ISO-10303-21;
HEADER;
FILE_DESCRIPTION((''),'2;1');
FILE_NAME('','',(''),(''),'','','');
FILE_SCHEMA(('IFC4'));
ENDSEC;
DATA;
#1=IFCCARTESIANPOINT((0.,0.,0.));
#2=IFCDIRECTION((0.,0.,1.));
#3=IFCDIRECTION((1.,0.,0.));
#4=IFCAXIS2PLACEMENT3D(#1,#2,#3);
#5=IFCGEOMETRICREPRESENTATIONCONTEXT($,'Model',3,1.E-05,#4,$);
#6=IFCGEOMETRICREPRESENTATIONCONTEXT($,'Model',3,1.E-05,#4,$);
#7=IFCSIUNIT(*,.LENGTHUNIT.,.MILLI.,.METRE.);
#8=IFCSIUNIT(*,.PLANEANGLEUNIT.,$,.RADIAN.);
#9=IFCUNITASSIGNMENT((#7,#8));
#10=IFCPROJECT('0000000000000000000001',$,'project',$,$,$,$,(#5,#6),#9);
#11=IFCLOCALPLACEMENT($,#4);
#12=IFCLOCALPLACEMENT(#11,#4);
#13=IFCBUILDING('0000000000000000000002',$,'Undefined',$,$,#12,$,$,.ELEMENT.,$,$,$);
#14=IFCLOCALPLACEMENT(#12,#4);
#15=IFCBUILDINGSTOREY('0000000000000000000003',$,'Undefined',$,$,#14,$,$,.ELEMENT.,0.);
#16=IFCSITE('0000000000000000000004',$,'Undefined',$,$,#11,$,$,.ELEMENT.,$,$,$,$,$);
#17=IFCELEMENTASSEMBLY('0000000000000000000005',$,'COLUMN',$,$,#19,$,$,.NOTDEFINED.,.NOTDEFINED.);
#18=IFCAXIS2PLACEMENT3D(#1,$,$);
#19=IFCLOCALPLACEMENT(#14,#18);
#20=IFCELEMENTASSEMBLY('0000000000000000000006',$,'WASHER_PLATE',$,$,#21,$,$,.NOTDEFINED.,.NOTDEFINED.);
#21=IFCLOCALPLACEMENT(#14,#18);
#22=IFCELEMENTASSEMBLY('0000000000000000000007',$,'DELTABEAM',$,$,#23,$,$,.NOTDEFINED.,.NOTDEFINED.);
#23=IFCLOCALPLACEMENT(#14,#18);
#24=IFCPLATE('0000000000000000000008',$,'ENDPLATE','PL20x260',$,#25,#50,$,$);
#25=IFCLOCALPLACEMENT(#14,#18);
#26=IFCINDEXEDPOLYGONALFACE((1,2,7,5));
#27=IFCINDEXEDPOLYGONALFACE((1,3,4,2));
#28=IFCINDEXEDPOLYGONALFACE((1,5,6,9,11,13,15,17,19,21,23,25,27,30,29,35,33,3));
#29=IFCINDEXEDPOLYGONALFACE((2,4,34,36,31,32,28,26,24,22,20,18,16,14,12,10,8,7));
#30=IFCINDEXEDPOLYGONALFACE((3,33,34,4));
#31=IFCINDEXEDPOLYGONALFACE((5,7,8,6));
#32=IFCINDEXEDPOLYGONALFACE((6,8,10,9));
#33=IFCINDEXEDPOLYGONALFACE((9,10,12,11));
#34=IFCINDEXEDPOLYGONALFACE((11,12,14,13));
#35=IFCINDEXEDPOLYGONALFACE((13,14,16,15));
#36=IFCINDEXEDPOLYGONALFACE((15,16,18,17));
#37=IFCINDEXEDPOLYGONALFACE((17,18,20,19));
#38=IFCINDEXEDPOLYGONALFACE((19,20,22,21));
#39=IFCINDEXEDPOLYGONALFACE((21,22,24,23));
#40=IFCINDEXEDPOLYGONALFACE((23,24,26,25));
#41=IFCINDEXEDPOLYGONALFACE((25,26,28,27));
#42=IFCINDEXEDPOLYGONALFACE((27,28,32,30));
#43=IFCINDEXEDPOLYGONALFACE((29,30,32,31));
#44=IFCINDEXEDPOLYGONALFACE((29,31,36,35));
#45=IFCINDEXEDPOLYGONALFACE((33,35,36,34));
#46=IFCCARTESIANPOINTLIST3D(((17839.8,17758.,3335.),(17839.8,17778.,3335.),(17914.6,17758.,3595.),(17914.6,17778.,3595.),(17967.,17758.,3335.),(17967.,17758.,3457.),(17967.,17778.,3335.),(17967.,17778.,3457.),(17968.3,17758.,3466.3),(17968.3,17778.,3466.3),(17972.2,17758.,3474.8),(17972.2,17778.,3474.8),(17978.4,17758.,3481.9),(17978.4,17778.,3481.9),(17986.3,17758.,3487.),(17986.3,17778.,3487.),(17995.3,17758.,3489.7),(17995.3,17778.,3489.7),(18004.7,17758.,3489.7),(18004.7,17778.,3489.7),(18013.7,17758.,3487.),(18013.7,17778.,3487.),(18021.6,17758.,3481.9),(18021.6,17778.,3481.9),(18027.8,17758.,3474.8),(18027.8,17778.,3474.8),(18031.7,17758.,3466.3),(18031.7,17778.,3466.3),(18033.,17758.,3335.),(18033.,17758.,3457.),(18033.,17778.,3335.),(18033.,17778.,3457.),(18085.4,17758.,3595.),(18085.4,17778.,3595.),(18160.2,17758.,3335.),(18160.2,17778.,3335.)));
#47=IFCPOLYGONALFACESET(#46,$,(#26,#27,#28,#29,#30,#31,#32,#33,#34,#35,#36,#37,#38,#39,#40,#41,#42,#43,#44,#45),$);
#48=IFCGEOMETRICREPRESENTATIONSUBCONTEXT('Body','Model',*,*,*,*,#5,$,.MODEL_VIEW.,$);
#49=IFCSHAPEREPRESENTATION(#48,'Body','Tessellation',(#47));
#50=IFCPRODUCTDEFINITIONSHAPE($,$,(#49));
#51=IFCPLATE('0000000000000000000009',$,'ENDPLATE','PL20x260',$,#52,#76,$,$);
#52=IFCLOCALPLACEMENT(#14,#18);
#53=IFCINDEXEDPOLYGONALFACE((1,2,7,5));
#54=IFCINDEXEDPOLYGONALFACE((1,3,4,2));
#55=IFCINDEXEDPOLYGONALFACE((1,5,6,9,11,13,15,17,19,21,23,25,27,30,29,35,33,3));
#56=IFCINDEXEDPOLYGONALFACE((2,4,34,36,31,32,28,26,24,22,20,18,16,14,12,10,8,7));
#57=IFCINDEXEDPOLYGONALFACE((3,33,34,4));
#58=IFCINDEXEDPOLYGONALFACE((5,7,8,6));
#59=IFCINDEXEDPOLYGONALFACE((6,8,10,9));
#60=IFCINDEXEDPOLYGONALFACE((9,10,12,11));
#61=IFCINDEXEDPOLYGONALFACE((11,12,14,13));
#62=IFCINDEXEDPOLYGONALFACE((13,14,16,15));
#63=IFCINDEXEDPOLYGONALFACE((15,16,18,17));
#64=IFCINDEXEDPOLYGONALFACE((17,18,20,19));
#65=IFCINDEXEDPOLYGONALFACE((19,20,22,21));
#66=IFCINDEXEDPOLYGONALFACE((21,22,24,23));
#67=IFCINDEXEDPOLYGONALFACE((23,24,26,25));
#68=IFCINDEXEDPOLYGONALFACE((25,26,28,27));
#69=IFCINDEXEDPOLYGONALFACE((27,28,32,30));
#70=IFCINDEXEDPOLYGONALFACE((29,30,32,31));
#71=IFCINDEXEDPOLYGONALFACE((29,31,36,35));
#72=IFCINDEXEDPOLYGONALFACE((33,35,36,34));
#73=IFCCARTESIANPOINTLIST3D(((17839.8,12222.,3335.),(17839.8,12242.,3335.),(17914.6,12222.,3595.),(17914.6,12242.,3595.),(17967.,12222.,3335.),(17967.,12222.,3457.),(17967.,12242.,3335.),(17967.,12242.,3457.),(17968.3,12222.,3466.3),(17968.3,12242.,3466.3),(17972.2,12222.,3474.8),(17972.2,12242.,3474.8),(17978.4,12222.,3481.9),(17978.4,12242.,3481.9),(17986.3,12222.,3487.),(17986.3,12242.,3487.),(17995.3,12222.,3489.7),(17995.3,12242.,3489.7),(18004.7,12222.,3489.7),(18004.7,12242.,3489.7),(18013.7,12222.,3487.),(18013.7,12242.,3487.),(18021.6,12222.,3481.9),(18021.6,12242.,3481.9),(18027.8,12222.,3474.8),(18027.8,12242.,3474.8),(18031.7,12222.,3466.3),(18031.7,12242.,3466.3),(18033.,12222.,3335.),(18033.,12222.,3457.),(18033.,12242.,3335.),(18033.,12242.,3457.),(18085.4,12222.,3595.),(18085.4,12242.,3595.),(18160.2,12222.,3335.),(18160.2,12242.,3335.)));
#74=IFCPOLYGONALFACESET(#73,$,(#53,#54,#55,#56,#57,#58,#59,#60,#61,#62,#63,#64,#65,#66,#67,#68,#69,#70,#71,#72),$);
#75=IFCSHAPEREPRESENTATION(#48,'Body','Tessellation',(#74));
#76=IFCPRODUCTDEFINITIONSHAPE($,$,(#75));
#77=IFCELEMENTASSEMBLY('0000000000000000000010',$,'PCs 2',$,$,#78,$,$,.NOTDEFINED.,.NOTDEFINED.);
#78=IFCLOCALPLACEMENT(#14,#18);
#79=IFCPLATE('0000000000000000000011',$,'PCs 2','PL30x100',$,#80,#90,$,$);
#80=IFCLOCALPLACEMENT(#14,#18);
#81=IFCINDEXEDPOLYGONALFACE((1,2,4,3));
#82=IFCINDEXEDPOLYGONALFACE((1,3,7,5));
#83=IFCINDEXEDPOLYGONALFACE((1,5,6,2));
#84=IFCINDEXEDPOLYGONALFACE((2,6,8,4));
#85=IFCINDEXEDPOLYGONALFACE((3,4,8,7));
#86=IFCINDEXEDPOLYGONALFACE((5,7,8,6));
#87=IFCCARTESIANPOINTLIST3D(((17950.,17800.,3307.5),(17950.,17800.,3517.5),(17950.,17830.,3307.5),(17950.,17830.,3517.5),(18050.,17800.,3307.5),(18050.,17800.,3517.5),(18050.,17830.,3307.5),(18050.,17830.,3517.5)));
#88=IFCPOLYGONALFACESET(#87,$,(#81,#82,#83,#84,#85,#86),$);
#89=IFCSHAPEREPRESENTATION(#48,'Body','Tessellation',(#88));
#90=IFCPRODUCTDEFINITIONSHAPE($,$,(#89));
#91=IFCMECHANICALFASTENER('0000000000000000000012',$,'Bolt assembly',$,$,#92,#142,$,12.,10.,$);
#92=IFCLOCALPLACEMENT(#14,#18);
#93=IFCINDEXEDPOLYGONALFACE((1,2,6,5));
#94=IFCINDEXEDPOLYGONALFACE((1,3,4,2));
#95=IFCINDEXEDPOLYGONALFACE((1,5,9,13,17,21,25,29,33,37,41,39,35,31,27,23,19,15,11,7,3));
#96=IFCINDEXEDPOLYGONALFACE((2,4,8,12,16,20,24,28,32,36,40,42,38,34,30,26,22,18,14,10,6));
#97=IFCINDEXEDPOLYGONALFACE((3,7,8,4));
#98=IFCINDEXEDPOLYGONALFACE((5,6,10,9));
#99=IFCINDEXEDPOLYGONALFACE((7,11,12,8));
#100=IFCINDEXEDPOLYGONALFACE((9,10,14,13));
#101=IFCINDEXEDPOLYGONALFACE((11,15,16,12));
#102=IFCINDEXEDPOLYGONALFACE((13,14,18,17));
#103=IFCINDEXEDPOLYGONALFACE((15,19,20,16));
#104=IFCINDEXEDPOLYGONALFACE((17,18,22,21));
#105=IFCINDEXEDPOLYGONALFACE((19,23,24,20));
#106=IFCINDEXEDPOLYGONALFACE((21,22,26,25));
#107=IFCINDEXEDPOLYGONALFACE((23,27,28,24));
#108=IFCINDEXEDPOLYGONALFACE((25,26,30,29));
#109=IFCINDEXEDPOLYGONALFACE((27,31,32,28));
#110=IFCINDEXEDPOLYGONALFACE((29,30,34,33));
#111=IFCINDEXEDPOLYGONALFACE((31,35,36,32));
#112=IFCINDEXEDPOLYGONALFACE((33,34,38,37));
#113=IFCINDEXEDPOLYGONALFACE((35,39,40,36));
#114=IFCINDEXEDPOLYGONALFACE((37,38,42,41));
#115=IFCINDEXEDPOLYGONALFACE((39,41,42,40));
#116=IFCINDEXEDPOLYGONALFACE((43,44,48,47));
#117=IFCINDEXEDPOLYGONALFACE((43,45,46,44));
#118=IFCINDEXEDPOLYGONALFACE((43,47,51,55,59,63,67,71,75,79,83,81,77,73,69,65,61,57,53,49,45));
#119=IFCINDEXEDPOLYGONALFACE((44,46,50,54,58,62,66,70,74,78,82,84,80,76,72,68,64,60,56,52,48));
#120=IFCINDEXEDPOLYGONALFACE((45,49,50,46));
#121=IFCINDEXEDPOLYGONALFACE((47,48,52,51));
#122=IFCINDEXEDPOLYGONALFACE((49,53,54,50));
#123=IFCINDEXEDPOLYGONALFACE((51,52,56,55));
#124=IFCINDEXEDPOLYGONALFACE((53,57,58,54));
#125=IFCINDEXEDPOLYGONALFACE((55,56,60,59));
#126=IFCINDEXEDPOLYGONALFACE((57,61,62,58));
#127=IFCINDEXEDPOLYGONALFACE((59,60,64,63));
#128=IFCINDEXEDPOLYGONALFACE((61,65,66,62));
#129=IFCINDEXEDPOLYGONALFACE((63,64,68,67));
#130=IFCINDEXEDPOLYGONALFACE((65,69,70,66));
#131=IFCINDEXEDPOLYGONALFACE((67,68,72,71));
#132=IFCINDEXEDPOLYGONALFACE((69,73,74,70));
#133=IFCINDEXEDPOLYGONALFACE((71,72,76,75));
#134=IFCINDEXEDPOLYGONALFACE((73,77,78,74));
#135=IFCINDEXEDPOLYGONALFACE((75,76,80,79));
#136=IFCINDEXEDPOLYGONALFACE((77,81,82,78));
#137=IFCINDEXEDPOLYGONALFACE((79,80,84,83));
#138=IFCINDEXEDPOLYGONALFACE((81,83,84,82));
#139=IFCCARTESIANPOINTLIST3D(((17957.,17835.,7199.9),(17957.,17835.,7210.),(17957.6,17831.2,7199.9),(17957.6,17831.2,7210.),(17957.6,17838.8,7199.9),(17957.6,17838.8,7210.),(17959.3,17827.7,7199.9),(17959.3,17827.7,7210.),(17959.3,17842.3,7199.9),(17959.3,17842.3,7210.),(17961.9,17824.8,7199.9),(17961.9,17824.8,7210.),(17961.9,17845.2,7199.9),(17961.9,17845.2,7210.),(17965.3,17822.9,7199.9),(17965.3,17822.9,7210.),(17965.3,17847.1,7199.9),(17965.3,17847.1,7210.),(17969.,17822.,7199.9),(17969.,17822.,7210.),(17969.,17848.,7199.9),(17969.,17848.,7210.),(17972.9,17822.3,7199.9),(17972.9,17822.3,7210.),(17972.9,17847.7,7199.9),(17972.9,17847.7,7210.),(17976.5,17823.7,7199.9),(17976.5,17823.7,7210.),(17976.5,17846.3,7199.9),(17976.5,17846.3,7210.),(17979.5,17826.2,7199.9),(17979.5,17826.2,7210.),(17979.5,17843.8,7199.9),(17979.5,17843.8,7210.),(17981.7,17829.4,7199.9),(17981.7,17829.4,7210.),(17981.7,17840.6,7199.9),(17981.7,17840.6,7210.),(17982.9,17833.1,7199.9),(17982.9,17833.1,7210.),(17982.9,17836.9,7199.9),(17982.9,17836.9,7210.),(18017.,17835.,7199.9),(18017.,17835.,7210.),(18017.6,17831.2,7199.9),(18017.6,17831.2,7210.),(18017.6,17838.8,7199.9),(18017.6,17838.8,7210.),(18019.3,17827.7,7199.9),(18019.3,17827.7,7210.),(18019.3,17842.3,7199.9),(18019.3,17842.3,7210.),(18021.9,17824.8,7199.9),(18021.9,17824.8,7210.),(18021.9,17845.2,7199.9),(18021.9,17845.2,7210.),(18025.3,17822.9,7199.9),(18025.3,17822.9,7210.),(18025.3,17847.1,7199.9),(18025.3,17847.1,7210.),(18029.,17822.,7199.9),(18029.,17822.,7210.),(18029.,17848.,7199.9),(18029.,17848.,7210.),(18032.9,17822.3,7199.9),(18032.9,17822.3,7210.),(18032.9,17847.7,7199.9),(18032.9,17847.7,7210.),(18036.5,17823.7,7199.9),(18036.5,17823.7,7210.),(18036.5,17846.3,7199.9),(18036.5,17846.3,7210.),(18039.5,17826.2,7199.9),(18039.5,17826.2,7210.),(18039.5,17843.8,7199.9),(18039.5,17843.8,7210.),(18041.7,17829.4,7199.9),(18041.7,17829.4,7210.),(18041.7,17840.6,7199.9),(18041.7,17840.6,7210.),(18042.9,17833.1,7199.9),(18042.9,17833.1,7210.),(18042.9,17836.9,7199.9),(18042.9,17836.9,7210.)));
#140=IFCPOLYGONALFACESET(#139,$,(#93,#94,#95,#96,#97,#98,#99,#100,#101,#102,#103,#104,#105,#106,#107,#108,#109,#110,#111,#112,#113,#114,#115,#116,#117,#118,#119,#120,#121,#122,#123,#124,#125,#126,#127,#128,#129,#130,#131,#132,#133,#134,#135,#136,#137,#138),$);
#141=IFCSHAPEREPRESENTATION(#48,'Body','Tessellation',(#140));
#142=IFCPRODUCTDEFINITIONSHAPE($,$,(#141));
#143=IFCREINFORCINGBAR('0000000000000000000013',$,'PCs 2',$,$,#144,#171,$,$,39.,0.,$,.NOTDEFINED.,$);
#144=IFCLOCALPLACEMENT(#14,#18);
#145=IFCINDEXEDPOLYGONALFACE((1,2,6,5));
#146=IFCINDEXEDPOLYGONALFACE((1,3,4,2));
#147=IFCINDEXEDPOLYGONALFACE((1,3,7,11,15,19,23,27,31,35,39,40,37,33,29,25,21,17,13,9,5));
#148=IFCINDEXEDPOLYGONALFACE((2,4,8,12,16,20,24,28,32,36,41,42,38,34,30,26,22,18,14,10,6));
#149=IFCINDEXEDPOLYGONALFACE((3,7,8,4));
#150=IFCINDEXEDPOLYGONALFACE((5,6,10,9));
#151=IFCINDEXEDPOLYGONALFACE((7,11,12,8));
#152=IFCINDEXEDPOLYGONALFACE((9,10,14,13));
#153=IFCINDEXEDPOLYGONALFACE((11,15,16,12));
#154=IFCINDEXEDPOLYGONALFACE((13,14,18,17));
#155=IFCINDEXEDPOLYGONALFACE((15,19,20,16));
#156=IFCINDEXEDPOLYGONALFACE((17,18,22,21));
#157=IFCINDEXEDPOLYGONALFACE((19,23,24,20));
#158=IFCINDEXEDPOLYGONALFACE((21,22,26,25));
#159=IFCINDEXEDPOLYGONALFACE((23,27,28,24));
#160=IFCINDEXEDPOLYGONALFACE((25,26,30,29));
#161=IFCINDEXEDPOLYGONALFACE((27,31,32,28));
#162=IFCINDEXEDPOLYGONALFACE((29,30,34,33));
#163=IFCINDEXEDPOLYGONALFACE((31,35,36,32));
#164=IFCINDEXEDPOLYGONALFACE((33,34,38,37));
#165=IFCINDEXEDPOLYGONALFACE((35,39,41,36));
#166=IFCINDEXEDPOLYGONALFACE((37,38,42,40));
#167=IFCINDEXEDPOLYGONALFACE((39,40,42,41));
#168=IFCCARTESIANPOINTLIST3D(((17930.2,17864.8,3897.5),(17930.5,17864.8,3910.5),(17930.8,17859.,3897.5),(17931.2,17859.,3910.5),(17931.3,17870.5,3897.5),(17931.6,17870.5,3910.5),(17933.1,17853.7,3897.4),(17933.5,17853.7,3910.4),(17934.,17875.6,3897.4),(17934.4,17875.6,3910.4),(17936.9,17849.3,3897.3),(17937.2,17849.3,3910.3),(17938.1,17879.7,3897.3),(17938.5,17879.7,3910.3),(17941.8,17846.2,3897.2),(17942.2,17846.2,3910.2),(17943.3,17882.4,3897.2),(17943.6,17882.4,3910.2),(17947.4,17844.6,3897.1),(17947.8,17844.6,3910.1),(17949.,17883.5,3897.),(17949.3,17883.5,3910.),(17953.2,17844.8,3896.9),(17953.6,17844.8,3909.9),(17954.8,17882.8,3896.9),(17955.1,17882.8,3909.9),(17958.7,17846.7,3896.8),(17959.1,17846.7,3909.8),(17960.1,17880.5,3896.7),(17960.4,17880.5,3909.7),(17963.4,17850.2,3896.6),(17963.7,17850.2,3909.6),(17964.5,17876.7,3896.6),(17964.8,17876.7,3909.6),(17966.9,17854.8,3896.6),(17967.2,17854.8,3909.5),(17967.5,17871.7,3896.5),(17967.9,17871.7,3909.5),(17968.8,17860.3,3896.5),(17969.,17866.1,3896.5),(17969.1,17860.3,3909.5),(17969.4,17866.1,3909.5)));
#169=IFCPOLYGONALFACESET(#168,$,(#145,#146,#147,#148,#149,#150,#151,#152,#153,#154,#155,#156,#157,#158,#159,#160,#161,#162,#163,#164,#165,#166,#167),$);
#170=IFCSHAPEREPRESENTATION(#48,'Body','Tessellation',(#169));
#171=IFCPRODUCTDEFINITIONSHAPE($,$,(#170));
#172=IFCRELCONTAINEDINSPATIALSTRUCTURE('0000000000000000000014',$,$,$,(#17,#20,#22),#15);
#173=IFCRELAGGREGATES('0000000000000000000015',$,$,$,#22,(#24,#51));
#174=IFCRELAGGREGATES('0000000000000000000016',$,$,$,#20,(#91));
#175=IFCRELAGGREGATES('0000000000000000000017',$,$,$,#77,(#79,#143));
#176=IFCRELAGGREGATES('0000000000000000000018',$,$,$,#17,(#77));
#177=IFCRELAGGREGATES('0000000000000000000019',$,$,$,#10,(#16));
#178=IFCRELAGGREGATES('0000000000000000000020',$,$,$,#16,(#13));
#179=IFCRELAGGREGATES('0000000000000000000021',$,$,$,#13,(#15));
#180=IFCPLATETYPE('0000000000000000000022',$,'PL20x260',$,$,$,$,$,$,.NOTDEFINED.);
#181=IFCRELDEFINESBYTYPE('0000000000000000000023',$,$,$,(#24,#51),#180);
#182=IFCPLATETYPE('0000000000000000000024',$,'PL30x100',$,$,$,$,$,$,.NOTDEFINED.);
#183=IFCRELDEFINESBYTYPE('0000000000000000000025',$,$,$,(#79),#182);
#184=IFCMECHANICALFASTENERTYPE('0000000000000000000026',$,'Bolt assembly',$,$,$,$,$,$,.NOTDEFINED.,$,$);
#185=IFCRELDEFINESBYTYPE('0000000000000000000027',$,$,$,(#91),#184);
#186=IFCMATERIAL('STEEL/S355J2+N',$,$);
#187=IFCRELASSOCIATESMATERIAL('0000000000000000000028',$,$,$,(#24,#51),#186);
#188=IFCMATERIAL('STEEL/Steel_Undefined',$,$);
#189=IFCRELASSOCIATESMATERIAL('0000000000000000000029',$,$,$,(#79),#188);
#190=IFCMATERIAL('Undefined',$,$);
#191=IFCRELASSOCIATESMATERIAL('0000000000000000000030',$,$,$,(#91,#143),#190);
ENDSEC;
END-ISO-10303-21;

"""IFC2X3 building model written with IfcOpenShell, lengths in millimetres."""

from ifc_helpers import new_model, entity, si_unit, frame, frame_2d, origin_with_axes, origin_2d_with_axis, place, context, subcontext, project, spatial, polyline, circle_curve, parameter, trimmed, segment, composite_curve, circle, outline, extrude, source, transform, mapped, material, type_object, element, aggregate, save


model = new_model("IFC2X3")

# Units and contexts
model_context_1 = context("Model", 3, precision=1e-05, world=origin_with_axes())
model_context_2 = context("Model", 3, precision=1e-05, world=origin_with_axes())
body_context = subcontext(model_context_1, "Body", "Model", "MODEL_VIEW")
ifc_project = project(units=[si_unit("LENGTHUNIT", "METRE", prefix="MILLI"), si_unit("PLANEANGLEUNIT", "RADIAN")], contexts=[model_context_1, model_context_2])

# Site, building, storey
site_placement = place(None, origin_with_axes())
site = spatial("IfcSite", under=ifc_project, at=site_placement, Name="Undefined", CompositionType="ELEMENT")
building_placement = place(site_placement, origin_with_axes())
building = spatial("IfcBuilding", under=site, at=building_placement, Name="Undefined", CompositionType="ELEMENT")
storey_placement = place(building_placement, origin_with_axes())
storey = spatial("IfcBuildingStorey", under=building, at=storey_placement, Name="Undefined", CompositionType="ELEMENT", Elevation=0.0)

# Element assembly
assembly_1_placement = place(storey_placement, origin_with_axes())
assembly_1 = element("IfcElementAssembly", 1, at=assembly_1_placement, inside=storey, Name="COLUMN", AssemblyPlace="NOTDEFINED", PredefinedType="NOTDEFINED")
ifc_material_1 = material(Name="STEEL/Steel_Undefined")

# Element assembly
assembly_2_placement = place(storey_placement, origin_with_axes())
assembly_2 = element("IfcElementAssembly", 2, at=assembly_2_placement, inside=storey, Name="WASHER_PLATE", AssemblyPlace="NOTDEFINED", PredefinedType="NOTDEFINED")

# Element assembly, plates, openings
assembly_3_placement = place(storey_placement, origin_with_axes())
assembly_3 = element("IfcElementAssembly", 3, at=assembly_3_placement, inside=storey, Name="DELTABEAM", AssemblyPlace="NOTDEFINED", PredefinedType="NOTDEFINED")
ifc_material_2 = material(Name="STEEL/S355J2+N")
plate_type_1 = type_object("IfcPlateType", Name="PL20x260", PredefinedType="NOTDEFINED")
plate_1_placement = place(assembly_3_placement, frame((17914.6, 17768.0, 3595.0), z_axis=(0.0, -1.0, 0.0), x_axis=(-0.276307, 0.0, -0.961069)))
plate_1 = element("IfcPlate", 4, at=plate_1_placement, type_object=plate_type_1, material=ifc_material_2, Name="ENDPLATE", Description="PL20x260", context=body_context, shape_type="SweptSolid", body=[
    extrude(outline(polyline([(0.0, 0.0), (270.5, 0.0), (182.0, 307.9), (-47.2, 164.2), (0.0, 0.0)])), frame((0.0, 0.0, -10.0), z_axis=(0.0, 0.0, 1.0), x_axis=(1.0, 0.0, 0.0)), (0.0, 0.0, 1.0), 20.0),
])
opening_1_placement = place(assembly_3_placement, frame((17914.6, 17768.0, 3595.0), z_axis=(0.0, -1.0, 0.0), x_axis=(-0.276307, 0.0, -0.961069)))
element("IfcOpeningElement", 5, at=opening_1_placement, cuts=plate_1, ObjectType="Recess", context=body_context, shape_type="SweptSolid", body=[
    extrude(outline(composite_curve([segment(trimmed(circle_curve(frame_2d((33.0, 33.0), x_axis=(-1.0, 0.0)), 33.0), [parameter(0.0)], [parameter(1.570796)], True, "PARAMETER"), True, "CONTINUOUS"), segment(polyline([(33.0, 0.0), (156.0, 0.0), (156.0, 66.0), (33.0, 66.0)]), True, "CONTINUOUS"), segment(trimmed(circle_curve(frame_2d((33.0, 33.0), x_axis=(0.0, 1.0)), 33.0), [parameter(0.0)], [parameter(1.570796)], True, "PARAMETER"), True, "CONTINUOUS"), segment(polyline([(0.0, 33.0), (0.0, 33.0)]), True, "CONTINUOUS")], self_intersect=True)), frame((86.4, 79.4, -11.0), z_axis=(0.0, 0.0, 1.0), x_axis=(0.961069, 0.276307, 0.0)), (0.0, 0.0, 1.0), 22.0),
])
plate_2_placement = place(assembly_3_placement, frame((18085.4, 12232.0, 3595.0), z_axis=(0.0, 1.0, 0.0), x_axis=(0.276307, 0.0, -0.961069)))
plate_2 = element("IfcPlate", 6, at=plate_2_placement, type_object=plate_type_1, material=ifc_material_2, Name="ENDPLATE", Description="PL20x260", context=body_context, shape_type="SweptSolid", body=[
    extrude(outline(polyline([(0.0, 0.0), (270.5, 0.0), (182.0, 307.9), (-47.2, 164.2), (0.0, 0.0)])), frame((0.0, 0.0, -10.0), z_axis=(0.0, 0.0, 1.0), x_axis=(1.0, 0.0, 0.0)), (0.0, 0.0, 1.0), 20.0),
])
opening_2_placement = place(assembly_3_placement, frame((18085.4, 12232.0, 3595.0), z_axis=(0.0, 1.0, 0.0), x_axis=(0.276307, 0.0, -0.961069)))
element("IfcOpeningElement", 7, at=opening_2_placement, cuts=plate_2, ObjectType="Recess", context=body_context, shape_type="SweptSolid", body=[
    extrude(outline(composite_curve([segment(trimmed(circle_curve(frame_2d((33.0, 33.0), x_axis=(-1.0, 0.0)), 33.0), [parameter(0.0)], [parameter(1.570796)], True, "PARAMETER"), True, "CONTINUOUS"), segment(polyline([(33.0, 0.0), (156.0, 0.0), (156.0, 66.0), (33.0, 66.0)]), True, "CONTINUOUS"), segment(trimmed(circle_curve(frame_2d((33.0, 33.0), x_axis=(0.0, 1.0)), 33.0), [parameter(0.0)], [parameter(1.570796)], True, "PARAMETER"), True, "CONTINUOUS"), segment(polyline([(0.0, 33.0), (0.0, 33.0)]), True, "CONTINUOUS")], self_intersect=True)), frame((86.4, 79.4, -11.0), z_axis=(0.0, 0.0, 1.0), x_axis=(0.961069, 0.276307, 0.0)), (0.0, 0.0, 1.0), 22.0),
])
aggregate(assembly_3, [plate_1, plate_2])

# Element assembly, plate
assembly_4_placement = place(assembly_1_placement, origin_with_axes())
assembly_4 = element("IfcElementAssembly", 8, at=assembly_4_placement, Name="PCs 2", AssemblyPlace="NOTDEFINED", PredefinedType="NOTDEFINED")
plate_type_2 = type_object("IfcPlateType", Name="PL30x100", PredefinedType="NOTDEFINED")
plate_3_placement = place(assembly_4_placement, frame((17950.0, 17815.0, 3517.5), z_axis=(0.0, -1.0, 0.0), x_axis=(0.0, 0.0, -1.0)))
plate_3 = element("IfcPlate", 9, at=plate_3_placement, type_object=plate_type_2, material=ifc_material_1, Name="PCs 2", Description="PL30x100", context=body_context, shape_type="SweptSolid", body=[
    extrude(outline(polyline([(0.0, 0.0), (210.0, 0.0), (210.0, 100.0), (0.0, 100.0), (0.0, 0.0)])), frame((0.0, 0.0, -15.0), z_axis=(0.0, 0.0, 1.0), x_axis=(1.0, 0.0, 0.0)), (0.0, 0.0, 1.0), 30.0),
])

# Mechanical fastener
ifc_material_3 = material(Name="Undefined")
mechanical_fastener_type = type_object("IfcMechanicalFastenerType", Name="Bolt assembly")
shared_shape_1 = source(origin_with_axes(), body_context, "Body", "SweptSolid", [
    extrude(circle(Radius=13.0, at=origin_2d_with_axis()), frame((0.0, 5.0, 0.0), z_axis=(0.0, 1.0, 0.0), x_axis=(1.0, 0.0, 0.0)), (0.0, 0.0, 1.0), 10.1),
])
mechanical_fastener_1_placement = place(assembly_2_placement, frame((18030.0, 17835.0, 7215.0), z_axis=(0.0, -1.0, 0.0), x_axis=(-1.0, 0.0, 0.0)))
mechanical_fastener_1 = element("IfcMechanicalFastener", 10, at=mechanical_fastener_1_placement, type_object=mechanical_fastener_type, material=ifc_material_3, Name="Bolt assembly", NominalDiameter=12.0, NominalLength=10.0, context=body_context, shape_type="MappedRepresentation", body=[
    mapped(shared_shape_1, transform((0.0, 0.0, 0.0))),
    mapped(shared_shape_1, transform((60.0, 0.0, 0.0))),
])
aggregate(assembly_2, [mechanical_fastener_1])

# Reinforcing bar
shared_shape_2 = source(origin_with_axes(), body_context, "Body", "AdvancedSweptSolid", [
    entity("IfcSweptDiskSolid", entity("IfcTrimmedCurve", entity("IfcLine", entity("IfcCartesianPoint", [0.0, 0.0, 0.0]), entity("IfcVector", entity("IfcDirection", [1.0, 0.0, 0.0]), 1.0)), [entity("IfcParameterValue", 0.0)], [entity("IfcParameterValue", 13.0)], True, "PARAMETER"), 19.5, None, 0.0, 13.0),
])
reinforcing_bar_1_placement = place(assembly_4_placement, frame((17949.7, 17864.0, 3897.0), z_axis=(0.704756, -0.709208, -0.018503), x_axis=(0.026246, 0.0, 0.999656)))
reinforcing_bar_1 = element("IfcReinforcingBar", 11, at=reinforcing_bar_1_placement, material=ifc_material_3, Name="PCs 2", BarRole="NOTDEFINED", CrossSectionArea=0.0, NominalDiameter=39.0, context=body_context, shape_type="MappedRepresentation", body=[
    mapped(shared_shape_2, transform((0.0, 0.0, 0.0))),
])
aggregate(assembly_4, [plate_3, reinforcing_bar_1])

aggregate(assembly_1, [assembly_4])

save(model, "model.ifc")
